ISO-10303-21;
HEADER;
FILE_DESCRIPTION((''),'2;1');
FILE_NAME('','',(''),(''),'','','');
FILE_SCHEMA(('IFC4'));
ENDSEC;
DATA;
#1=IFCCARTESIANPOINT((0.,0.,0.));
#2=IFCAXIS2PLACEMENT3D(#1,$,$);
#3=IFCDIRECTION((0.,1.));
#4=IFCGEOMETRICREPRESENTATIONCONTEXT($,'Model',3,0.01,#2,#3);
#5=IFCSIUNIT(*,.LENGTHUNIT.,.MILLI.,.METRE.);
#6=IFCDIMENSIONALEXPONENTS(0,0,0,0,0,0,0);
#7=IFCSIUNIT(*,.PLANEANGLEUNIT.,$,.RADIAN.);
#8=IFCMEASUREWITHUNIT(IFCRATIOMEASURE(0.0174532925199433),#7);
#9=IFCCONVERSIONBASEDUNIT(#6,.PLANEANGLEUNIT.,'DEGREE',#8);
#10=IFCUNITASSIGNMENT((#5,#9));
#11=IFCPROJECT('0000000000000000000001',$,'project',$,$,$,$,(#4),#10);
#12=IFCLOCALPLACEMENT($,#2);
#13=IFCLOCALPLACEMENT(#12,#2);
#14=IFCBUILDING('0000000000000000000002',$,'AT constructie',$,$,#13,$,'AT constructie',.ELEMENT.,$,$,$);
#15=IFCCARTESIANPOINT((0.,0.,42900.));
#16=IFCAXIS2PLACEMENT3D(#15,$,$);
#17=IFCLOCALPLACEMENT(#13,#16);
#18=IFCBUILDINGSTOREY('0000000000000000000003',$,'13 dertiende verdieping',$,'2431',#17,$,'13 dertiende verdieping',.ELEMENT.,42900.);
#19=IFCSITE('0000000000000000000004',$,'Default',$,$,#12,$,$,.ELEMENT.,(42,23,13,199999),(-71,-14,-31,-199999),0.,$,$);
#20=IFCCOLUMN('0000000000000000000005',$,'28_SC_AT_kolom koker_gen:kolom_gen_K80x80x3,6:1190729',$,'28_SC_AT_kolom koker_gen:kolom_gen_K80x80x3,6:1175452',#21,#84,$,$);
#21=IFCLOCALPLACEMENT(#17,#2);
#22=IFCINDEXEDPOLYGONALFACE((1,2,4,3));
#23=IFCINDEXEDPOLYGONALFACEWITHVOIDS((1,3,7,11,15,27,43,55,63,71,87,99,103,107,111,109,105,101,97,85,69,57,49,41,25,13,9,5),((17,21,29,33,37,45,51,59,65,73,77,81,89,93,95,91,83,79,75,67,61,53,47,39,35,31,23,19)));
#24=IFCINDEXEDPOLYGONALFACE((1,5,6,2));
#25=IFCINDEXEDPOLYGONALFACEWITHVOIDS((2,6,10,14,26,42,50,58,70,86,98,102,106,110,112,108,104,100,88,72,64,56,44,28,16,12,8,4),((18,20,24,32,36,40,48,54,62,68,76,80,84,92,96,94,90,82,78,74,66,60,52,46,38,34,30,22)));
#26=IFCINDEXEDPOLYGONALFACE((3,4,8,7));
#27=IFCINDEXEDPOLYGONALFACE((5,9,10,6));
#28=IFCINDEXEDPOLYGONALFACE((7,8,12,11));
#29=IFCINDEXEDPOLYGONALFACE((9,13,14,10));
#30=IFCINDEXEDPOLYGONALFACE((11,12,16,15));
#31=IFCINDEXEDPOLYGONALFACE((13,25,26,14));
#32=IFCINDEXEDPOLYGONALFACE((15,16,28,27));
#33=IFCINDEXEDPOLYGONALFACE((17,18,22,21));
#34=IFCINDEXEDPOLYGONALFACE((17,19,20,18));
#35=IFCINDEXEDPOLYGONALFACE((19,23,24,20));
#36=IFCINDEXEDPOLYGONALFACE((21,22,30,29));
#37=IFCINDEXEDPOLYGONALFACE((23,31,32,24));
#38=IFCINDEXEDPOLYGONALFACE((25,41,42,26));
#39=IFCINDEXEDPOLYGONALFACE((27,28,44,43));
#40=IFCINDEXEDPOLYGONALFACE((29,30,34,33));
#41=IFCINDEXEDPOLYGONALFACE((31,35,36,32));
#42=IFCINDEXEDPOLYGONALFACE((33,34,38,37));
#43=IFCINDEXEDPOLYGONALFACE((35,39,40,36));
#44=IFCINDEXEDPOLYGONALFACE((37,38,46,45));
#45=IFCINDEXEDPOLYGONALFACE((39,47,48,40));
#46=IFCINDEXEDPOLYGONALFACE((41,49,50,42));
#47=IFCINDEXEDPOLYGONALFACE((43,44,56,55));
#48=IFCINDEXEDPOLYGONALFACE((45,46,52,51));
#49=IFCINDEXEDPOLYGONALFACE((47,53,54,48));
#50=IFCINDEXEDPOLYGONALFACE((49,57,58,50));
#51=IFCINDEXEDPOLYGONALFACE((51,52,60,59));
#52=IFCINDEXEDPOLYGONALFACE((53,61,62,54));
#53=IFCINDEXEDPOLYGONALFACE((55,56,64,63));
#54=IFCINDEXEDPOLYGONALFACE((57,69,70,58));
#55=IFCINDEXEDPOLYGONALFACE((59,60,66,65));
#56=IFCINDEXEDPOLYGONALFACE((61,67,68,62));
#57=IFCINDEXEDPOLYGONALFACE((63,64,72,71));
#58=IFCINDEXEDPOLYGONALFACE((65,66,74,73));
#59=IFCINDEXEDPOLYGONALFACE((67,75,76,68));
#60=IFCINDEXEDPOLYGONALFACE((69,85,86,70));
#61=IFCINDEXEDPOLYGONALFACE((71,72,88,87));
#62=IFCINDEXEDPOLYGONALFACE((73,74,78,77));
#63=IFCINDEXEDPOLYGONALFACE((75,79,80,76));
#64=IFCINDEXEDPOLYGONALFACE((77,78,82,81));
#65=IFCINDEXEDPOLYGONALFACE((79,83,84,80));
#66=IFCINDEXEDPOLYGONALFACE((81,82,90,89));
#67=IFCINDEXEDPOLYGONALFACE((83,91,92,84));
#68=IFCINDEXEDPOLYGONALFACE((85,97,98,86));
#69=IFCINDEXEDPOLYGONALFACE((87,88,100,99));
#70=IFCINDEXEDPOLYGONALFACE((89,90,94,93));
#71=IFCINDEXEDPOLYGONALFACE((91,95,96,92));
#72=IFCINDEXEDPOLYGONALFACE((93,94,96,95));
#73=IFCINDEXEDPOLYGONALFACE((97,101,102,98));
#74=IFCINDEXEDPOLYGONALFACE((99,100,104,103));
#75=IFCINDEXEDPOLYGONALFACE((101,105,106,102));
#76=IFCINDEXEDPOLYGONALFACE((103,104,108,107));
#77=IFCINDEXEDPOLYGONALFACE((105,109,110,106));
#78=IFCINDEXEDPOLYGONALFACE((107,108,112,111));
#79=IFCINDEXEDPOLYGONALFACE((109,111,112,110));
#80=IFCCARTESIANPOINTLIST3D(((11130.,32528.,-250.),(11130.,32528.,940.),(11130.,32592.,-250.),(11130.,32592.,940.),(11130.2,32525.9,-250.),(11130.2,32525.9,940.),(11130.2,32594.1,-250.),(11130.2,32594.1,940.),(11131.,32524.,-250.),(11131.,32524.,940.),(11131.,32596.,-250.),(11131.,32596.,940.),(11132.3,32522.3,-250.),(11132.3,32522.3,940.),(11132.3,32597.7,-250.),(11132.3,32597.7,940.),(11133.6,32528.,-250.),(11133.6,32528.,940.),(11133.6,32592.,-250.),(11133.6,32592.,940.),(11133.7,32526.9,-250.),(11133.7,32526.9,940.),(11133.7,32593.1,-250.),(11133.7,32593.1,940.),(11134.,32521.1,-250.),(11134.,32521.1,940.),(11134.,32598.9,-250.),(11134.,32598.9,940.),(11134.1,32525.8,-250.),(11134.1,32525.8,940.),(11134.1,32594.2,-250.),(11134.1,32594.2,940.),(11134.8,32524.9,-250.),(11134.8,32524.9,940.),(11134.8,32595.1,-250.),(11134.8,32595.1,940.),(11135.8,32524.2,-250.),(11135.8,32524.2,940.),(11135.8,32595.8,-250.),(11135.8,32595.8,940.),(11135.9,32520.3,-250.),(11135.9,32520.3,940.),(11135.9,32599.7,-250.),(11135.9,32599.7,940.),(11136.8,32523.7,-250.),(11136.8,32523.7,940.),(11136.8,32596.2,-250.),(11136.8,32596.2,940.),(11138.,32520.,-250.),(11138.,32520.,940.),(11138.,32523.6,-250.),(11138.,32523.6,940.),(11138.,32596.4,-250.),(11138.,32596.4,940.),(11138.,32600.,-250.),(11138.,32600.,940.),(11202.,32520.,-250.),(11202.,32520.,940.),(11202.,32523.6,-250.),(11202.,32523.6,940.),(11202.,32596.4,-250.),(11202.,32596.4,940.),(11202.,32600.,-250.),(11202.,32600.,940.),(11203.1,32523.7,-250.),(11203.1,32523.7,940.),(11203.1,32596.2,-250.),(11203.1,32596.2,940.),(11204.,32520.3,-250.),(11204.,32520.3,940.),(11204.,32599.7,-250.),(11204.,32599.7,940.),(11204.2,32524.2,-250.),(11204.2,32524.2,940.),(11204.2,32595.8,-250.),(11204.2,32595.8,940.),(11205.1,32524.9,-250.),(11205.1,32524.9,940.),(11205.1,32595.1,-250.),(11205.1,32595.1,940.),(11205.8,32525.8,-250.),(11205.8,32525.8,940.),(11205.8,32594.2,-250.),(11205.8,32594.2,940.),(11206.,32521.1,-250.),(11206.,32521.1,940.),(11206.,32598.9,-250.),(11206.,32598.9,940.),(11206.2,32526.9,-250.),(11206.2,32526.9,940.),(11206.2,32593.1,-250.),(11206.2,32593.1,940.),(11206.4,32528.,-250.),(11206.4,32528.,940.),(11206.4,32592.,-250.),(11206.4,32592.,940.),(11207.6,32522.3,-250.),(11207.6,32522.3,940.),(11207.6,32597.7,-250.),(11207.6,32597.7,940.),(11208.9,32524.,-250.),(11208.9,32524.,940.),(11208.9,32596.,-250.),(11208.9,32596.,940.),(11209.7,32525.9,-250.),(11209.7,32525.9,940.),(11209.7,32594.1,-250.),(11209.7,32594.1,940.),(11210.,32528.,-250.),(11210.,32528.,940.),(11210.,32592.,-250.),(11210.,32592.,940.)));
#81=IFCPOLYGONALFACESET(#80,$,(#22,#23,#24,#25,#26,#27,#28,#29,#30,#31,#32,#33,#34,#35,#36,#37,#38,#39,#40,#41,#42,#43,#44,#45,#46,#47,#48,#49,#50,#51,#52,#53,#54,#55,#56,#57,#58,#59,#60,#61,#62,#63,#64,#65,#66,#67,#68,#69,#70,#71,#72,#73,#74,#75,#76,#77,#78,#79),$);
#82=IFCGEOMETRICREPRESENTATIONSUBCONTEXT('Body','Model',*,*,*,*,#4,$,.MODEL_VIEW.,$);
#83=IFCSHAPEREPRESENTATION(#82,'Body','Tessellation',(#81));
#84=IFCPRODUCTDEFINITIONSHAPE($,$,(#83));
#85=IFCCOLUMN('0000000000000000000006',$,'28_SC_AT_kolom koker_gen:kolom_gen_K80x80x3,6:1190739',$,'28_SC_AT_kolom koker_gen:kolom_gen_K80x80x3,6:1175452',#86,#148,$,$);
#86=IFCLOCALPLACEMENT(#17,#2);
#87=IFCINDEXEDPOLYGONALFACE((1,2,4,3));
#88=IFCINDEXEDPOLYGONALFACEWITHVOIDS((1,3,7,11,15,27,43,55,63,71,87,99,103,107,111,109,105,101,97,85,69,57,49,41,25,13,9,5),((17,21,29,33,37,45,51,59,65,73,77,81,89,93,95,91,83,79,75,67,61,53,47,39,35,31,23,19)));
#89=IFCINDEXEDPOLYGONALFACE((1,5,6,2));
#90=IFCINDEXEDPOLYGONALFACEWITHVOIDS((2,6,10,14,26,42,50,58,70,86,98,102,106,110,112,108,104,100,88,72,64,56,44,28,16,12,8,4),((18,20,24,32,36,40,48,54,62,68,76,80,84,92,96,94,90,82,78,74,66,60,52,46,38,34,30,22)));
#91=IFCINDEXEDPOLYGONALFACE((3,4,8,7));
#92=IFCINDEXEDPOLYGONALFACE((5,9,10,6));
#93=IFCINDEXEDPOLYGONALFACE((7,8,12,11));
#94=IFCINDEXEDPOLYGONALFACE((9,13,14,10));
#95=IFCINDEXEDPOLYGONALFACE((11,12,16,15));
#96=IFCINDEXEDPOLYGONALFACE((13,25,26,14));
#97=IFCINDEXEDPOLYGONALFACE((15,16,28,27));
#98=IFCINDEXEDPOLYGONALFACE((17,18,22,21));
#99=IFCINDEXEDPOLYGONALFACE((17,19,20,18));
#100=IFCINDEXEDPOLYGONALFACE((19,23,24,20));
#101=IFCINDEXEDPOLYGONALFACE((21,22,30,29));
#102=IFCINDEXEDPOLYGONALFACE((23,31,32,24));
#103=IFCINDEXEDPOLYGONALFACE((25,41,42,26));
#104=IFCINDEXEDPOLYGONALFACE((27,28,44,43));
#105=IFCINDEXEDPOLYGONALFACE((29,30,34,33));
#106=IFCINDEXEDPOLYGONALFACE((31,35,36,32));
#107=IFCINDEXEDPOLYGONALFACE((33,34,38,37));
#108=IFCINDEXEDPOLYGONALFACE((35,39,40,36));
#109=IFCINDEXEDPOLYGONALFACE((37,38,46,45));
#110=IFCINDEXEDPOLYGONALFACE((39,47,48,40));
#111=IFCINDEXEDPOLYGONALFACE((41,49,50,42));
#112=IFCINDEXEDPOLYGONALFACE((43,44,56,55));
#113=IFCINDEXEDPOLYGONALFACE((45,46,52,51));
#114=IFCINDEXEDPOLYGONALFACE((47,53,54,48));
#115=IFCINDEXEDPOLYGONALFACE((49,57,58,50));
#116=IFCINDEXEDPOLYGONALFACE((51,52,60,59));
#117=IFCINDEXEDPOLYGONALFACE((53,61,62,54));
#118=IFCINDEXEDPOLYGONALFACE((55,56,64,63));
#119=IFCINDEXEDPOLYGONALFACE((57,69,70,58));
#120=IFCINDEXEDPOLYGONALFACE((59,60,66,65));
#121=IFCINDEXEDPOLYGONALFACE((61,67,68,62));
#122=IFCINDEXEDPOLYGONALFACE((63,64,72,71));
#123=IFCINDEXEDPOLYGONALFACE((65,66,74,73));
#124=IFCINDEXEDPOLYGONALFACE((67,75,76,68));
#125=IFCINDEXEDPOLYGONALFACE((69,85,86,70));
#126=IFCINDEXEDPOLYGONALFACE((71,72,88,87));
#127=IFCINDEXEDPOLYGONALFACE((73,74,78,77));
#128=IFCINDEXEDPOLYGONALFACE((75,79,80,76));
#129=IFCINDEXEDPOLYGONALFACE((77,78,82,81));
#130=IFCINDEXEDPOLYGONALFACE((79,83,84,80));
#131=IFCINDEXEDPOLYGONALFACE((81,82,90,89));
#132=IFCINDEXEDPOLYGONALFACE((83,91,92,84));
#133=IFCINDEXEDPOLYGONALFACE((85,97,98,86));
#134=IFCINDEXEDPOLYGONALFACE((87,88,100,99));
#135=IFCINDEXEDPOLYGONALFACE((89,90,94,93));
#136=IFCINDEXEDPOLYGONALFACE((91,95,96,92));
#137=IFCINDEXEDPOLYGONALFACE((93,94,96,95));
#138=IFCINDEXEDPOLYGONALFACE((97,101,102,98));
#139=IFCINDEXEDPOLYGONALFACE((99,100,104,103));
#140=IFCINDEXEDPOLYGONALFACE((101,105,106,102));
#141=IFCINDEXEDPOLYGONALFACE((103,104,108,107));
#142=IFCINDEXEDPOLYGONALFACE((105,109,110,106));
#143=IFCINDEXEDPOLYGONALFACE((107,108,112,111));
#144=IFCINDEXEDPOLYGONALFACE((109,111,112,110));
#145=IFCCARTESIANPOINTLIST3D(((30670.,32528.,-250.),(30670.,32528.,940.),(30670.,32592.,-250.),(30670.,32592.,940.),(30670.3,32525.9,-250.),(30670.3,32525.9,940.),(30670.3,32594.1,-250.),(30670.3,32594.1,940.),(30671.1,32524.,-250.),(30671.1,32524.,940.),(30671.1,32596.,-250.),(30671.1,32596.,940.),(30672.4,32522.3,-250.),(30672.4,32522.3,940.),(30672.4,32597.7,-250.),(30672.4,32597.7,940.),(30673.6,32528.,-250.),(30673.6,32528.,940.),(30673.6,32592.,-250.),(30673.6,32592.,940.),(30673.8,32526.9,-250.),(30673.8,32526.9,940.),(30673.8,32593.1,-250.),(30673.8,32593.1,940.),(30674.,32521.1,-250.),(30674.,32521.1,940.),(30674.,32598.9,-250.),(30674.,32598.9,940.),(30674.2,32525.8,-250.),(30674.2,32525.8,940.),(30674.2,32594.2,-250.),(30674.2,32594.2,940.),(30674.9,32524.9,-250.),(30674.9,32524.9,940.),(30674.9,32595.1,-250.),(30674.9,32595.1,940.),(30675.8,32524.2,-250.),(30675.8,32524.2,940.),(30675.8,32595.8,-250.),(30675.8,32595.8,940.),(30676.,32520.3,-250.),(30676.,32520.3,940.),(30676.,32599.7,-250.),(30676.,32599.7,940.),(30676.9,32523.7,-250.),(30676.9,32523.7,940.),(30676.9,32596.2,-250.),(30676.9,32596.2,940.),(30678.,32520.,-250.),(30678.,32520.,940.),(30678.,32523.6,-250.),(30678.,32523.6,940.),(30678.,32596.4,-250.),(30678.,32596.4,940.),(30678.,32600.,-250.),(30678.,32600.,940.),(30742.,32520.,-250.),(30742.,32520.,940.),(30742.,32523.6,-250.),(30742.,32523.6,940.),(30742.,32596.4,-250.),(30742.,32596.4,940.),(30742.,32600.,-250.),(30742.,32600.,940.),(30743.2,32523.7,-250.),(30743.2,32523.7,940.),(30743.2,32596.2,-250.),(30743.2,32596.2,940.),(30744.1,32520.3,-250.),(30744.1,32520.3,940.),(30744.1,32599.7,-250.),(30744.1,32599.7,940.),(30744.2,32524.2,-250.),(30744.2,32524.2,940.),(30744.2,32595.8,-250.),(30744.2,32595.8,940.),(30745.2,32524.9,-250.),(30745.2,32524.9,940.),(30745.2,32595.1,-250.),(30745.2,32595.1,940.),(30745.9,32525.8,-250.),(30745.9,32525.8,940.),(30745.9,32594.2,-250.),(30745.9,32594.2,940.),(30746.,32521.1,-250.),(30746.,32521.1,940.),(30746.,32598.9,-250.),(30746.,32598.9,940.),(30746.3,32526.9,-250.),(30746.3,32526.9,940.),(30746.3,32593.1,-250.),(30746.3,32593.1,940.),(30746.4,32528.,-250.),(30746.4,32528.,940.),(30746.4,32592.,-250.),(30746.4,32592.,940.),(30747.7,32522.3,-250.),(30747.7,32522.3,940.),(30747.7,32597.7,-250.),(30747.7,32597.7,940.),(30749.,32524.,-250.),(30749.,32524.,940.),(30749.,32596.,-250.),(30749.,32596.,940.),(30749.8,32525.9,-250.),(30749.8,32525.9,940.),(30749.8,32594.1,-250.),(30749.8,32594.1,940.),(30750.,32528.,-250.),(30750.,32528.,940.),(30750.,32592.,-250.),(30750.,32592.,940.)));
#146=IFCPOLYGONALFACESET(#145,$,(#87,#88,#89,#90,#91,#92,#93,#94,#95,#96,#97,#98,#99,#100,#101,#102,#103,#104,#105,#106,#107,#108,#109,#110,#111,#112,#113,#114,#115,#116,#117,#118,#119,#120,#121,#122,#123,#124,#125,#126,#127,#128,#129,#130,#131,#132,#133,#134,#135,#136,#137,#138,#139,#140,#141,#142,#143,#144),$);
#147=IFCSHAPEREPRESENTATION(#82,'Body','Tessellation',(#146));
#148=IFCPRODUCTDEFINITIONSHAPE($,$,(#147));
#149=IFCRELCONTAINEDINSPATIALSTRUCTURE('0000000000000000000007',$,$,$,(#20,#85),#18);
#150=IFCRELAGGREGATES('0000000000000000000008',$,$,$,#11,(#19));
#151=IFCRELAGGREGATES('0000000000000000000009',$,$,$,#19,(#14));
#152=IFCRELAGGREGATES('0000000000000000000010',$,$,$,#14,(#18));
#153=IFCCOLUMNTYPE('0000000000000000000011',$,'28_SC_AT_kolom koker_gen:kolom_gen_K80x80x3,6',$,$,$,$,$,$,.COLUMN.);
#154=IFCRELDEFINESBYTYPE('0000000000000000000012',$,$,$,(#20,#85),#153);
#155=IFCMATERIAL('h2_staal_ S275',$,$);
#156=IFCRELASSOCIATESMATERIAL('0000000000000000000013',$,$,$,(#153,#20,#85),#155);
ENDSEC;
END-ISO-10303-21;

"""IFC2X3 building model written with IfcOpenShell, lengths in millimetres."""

from ifc_helpers import new_model, entity, si_unit, converted_unit, direction, frame, frame_2d, origin, place, context, subcontext, project, spatial, polyline, circle_curve, parameter, trimmed, segment, composite_curve, outline, extrude, source, transform, mapped, material, type_object, type_shapes, element, save


model = new_model("IFC2X3")

# Units and contexts
model_context = context("Model", 3, precision=0.01, world=origin(), true_north=direction((0.0, 1.0)))
body_context = subcontext(model_context, "Body", "Model", "MODEL_VIEW")
ifc_project = project(units=[si_unit("LENGTHUNIT", "METRE", prefix="MILLI"), converted_unit("PLANEANGLEUNIT", "DEGREE", entity("IfcRatioMeasure", 0.0174532925199433), si_unit("PLANEANGLEUNIT", "RADIAN"), dimensions=[0, 0, 0, 0, 0, 0, 0])], contexts=[model_context])

# Site, building, storey
site_placement = place(None, origin())
site = spatial("IfcSite", under=ifc_project, at=site_placement, Name="Default", CompositionType="ELEMENT", RefLatitude=(42, 23, 13, 199999), RefLongitude=(-71, -14, -31, -199999), RefElevation=0.0)
building_placement = place(site_placement, origin())
building = spatial("IfcBuilding", under=site, at=building_placement, Name="AT constructie", LongName="AT constructie", CompositionType="ELEMENT")
storey_placement = place(building_placement, frame((0.0, 0.0, 42900.0)))
storey = spatial("IfcBuildingStorey", under=building, at=storey_placement, Name="13 dertiende verdieping", ObjectType="2431", LongName="13 dertiende verdieping", CompositionType="ELEMENT", Elevation=42900.0)

# Columns
ifc_material = material(Name="h2_staal_ S275")
column_type_1 = type_object("IfcColumnType", Name="28_SC_AT_kolom koker_gen:kolom_gen_K80x80x3,6", PredefinedType="COLUMN", material=ifc_material)
shared_shape_1 = source(origin(), body_context, "Body", "SweptSolid", [
    extrude(outline(composite_curve([segment(trimmed(circle_curve(frame_2d((32.0, 32.0), x_axis=(1.0, 0.0)), 8.0), [parameter(360.0)], [parameter(90.0)], True, "PARAMETER"), True, "CONTINUOUS"), segment(polyline([(32.0, 40.0), (-32.0, 40.0)]), True, "CONTINUOUS"), segment(trimmed(circle_curve(frame_2d((-32.0, 32.0), x_axis=(1.0, 0.0)), 8.0), [parameter(90.0)], [parameter(180.0)], True, "PARAMETER"), True, "CONTINUOUS"), segment(polyline([(-40.0, 32.0), (-40.0, -32.0)]), True, "CONTINUOUS"), segment(trimmed(circle_curve(frame_2d((-32.0, -32.0), x_axis=(1.0, 0.0)), 8.0), [parameter(180.0)], [parameter(270.0)], True, "PARAMETER"), True, "CONTINUOUS"), segment(polyline([(-32.0, -40.0), (32.0, -40.0)]), True, "CONTINUOUS"), segment(trimmed(circle_curve(frame_2d((32.0, -32.0), x_axis=(1.0, 0.0)), 8.0), [parameter(270.0)], [parameter(0.0)], True, "PARAMETER"), True, "CONTINUOUS"), segment(polyline([(40.0, -32.0), (40.0, 32.0)]), True, "CONTINUOUS")], self_intersect=False), holes=[composite_curve([segment(polyline([(-32.0, 36.4), (32.0, 36.4)]), True, "CONTINUOUS"), segment(trimmed(circle_curve(frame_2d((32.0, 32.0), x_axis=(1.0, 0.0)), 4.4), [parameter(360.0)], [parameter(90.0)], True, "PARAMETER"), False, "CONTINUOUS"), segment(polyline([(36.4, 32.0), (36.4, -32.0)]), True, "CONTINUOUS"), segment(trimmed(circle_curve(frame_2d((32.0, -32.0), x_axis=(1.0, 0.0)), 4.4), [parameter(270.0)], [parameter(360.0)], True, "PARAMETER"), False, "CONTINUOUS"), segment(polyline([(32.0, -36.4), (-32.0, -36.4)]), True, "CONTINUOUS"), segment(trimmed(circle_curve(frame_2d((-32.0, -32.0), x_axis=(1.0, 0.0)), 4.4), [parameter(180.0)], [parameter(270.0)], True, "PARAMETER"), False, "CONTINUOUS"), segment(polyline([(-36.4, -32.0), (-36.4, 32.0)]), True, "CONTINUOUS"), segment(trimmed(circle_curve(frame_2d((-32.0, 32.0), x_axis=(1.0, 0.0)), 4.4), [parameter(90.0)], [parameter(180.0)], True, "PARAMETER"), False, "CONTINUOUS")], self_intersect=False)]), frame((0.0, 0.0, 42650.0), z_axis=(0.0, 0.0, 1.0), x_axis=(-1.0, 0.0, 0.0)), (0.0, 0.0, 1.0), 1190.0),
])
type_shapes(column_type_1, [shared_shape_1])
for number, where, name in (
    (1, (11170.0, 32560.0, -42900.0), "28_SC_AT_kolom koker_gen:kolom_gen_K80x80x3,6:1190729"),
    (2, (30710.0, 32560.0, -42900.0), "28_SC_AT_kolom koker_gen:kolom_gen_K80x80x3,6:1190739"),
):
    element("IfcColumn", number, at=place(storey_placement, frame(where)), inside=storey, type_object=column_type_1, material=ifc_material, Name=name, ObjectType="28_SC_AT_kolom koker_gen:kolom_gen_K80x80x3,6:1175452", context=body_context, shape_type="MappedRepresentation", body=[
        mapped(shared_shape_1, transform((0.0, 0.0, 0.0), scale=1.0)),
    ])

save(model, "model.ifc")
